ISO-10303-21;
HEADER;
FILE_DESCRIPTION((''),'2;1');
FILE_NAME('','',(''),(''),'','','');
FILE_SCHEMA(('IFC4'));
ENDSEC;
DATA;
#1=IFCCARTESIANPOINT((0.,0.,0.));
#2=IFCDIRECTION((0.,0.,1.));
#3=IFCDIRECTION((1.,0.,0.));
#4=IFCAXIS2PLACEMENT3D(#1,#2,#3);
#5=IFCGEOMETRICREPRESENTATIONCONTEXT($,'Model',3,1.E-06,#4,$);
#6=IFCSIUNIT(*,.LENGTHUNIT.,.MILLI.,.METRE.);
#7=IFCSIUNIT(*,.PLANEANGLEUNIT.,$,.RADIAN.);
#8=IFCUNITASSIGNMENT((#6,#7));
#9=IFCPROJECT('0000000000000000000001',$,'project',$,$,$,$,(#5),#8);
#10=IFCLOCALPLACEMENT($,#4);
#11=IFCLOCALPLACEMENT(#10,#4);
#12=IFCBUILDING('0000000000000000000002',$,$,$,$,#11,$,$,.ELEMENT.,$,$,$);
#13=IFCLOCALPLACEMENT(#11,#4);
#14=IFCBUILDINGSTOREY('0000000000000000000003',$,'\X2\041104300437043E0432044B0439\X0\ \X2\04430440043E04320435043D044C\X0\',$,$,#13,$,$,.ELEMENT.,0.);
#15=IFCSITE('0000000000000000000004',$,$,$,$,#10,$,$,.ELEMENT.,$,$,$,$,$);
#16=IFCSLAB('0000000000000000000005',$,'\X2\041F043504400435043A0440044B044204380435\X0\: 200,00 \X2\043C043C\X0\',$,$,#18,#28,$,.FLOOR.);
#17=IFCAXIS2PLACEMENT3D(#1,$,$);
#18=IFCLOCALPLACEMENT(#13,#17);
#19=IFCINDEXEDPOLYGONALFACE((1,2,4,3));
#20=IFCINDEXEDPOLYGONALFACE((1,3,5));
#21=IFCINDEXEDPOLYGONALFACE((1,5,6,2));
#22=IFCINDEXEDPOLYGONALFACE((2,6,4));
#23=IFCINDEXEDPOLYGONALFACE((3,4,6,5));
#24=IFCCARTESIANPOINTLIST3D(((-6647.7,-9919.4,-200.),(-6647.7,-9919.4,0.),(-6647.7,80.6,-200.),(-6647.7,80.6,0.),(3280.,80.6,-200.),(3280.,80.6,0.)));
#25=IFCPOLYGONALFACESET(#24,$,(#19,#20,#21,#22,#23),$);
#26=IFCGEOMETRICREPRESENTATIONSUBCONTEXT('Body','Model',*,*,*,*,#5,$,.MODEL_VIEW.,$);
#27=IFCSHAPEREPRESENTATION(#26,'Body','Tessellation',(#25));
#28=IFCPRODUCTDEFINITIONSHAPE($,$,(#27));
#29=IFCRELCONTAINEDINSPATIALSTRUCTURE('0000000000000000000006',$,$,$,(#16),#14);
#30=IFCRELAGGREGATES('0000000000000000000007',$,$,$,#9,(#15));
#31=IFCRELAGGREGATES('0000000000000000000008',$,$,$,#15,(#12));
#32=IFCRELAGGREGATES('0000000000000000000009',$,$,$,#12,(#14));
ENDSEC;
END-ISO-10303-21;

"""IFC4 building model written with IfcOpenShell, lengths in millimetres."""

from ifc_helpers import new_model, si_unit, frame, origin_with_axes, place, context, subcontext, project, spatial, line, indexed_curve, outline, extrude, source, transform, mapped, element, save


model = new_model("IFC4")

# Units and contexts
model_context = context("Model", 3, precision=1e-06, world=origin_with_axes())
body_context = subcontext(model_context, "Body", "Model", "MODEL_VIEW")
ifc_project = project(units=[si_unit("LENGTHUNIT", "METRE", prefix="MILLI"), si_unit("PLANEANGLEUNIT", "RADIAN")], contexts=[model_context])

# Site, building, storey
site_placement = place(None, origin_with_axes())
site = spatial("IfcSite", under=ifc_project, at=site_placement, CompositionType="ELEMENT")
building_placement = place(site_placement, origin_with_axes())
building = spatial("IfcBuilding", under=site, at=building_placement, CompositionType="ELEMENT")
storey_placement = place(building_placement, origin_with_axes())
storey = spatial("IfcBuildingStorey", under=building, at=storey_placement, Name="Базовый уровень", CompositionType="ELEMENT", Elevation=0.0)

# Slab
shared_shape = source(origin_with_axes(), body_context, "Body", "SweptSolid", [
    extrude(outline(indexed_curve([(0.0, 0.0), (10000.0, 0.0), (10000.0, -9927.7)], segments=[line(1, 2), line(2, 3), line(3, 1)])), origin_with_axes(), (0.0, 0.0, 1.0), 200.0),
])
slab_placement = place(storey_placement, frame((-6647.7, -9919.4, -200.0), z_axis=(0.0, 0.0, 1.0), x_axis=(0.0, 1.0, 0.0)))
element("IfcSlab", 1, at=slab_placement, inside=storey, Name="Перекрытие: 200,00 мм", PredefinedType="FLOOR", context=body_context, shape_type="MappedRepresentation", body=[
    mapped(shared_shape, transform((0.0, 0.0, 0.0), x_axis=(1.0, 0.0, 0.0), y_axis=(0.0, 1.0, 0.0), z_axis=(0.0, 0.0, 1.0), scale=1.0)),
])

save(model, "model.ifc")
